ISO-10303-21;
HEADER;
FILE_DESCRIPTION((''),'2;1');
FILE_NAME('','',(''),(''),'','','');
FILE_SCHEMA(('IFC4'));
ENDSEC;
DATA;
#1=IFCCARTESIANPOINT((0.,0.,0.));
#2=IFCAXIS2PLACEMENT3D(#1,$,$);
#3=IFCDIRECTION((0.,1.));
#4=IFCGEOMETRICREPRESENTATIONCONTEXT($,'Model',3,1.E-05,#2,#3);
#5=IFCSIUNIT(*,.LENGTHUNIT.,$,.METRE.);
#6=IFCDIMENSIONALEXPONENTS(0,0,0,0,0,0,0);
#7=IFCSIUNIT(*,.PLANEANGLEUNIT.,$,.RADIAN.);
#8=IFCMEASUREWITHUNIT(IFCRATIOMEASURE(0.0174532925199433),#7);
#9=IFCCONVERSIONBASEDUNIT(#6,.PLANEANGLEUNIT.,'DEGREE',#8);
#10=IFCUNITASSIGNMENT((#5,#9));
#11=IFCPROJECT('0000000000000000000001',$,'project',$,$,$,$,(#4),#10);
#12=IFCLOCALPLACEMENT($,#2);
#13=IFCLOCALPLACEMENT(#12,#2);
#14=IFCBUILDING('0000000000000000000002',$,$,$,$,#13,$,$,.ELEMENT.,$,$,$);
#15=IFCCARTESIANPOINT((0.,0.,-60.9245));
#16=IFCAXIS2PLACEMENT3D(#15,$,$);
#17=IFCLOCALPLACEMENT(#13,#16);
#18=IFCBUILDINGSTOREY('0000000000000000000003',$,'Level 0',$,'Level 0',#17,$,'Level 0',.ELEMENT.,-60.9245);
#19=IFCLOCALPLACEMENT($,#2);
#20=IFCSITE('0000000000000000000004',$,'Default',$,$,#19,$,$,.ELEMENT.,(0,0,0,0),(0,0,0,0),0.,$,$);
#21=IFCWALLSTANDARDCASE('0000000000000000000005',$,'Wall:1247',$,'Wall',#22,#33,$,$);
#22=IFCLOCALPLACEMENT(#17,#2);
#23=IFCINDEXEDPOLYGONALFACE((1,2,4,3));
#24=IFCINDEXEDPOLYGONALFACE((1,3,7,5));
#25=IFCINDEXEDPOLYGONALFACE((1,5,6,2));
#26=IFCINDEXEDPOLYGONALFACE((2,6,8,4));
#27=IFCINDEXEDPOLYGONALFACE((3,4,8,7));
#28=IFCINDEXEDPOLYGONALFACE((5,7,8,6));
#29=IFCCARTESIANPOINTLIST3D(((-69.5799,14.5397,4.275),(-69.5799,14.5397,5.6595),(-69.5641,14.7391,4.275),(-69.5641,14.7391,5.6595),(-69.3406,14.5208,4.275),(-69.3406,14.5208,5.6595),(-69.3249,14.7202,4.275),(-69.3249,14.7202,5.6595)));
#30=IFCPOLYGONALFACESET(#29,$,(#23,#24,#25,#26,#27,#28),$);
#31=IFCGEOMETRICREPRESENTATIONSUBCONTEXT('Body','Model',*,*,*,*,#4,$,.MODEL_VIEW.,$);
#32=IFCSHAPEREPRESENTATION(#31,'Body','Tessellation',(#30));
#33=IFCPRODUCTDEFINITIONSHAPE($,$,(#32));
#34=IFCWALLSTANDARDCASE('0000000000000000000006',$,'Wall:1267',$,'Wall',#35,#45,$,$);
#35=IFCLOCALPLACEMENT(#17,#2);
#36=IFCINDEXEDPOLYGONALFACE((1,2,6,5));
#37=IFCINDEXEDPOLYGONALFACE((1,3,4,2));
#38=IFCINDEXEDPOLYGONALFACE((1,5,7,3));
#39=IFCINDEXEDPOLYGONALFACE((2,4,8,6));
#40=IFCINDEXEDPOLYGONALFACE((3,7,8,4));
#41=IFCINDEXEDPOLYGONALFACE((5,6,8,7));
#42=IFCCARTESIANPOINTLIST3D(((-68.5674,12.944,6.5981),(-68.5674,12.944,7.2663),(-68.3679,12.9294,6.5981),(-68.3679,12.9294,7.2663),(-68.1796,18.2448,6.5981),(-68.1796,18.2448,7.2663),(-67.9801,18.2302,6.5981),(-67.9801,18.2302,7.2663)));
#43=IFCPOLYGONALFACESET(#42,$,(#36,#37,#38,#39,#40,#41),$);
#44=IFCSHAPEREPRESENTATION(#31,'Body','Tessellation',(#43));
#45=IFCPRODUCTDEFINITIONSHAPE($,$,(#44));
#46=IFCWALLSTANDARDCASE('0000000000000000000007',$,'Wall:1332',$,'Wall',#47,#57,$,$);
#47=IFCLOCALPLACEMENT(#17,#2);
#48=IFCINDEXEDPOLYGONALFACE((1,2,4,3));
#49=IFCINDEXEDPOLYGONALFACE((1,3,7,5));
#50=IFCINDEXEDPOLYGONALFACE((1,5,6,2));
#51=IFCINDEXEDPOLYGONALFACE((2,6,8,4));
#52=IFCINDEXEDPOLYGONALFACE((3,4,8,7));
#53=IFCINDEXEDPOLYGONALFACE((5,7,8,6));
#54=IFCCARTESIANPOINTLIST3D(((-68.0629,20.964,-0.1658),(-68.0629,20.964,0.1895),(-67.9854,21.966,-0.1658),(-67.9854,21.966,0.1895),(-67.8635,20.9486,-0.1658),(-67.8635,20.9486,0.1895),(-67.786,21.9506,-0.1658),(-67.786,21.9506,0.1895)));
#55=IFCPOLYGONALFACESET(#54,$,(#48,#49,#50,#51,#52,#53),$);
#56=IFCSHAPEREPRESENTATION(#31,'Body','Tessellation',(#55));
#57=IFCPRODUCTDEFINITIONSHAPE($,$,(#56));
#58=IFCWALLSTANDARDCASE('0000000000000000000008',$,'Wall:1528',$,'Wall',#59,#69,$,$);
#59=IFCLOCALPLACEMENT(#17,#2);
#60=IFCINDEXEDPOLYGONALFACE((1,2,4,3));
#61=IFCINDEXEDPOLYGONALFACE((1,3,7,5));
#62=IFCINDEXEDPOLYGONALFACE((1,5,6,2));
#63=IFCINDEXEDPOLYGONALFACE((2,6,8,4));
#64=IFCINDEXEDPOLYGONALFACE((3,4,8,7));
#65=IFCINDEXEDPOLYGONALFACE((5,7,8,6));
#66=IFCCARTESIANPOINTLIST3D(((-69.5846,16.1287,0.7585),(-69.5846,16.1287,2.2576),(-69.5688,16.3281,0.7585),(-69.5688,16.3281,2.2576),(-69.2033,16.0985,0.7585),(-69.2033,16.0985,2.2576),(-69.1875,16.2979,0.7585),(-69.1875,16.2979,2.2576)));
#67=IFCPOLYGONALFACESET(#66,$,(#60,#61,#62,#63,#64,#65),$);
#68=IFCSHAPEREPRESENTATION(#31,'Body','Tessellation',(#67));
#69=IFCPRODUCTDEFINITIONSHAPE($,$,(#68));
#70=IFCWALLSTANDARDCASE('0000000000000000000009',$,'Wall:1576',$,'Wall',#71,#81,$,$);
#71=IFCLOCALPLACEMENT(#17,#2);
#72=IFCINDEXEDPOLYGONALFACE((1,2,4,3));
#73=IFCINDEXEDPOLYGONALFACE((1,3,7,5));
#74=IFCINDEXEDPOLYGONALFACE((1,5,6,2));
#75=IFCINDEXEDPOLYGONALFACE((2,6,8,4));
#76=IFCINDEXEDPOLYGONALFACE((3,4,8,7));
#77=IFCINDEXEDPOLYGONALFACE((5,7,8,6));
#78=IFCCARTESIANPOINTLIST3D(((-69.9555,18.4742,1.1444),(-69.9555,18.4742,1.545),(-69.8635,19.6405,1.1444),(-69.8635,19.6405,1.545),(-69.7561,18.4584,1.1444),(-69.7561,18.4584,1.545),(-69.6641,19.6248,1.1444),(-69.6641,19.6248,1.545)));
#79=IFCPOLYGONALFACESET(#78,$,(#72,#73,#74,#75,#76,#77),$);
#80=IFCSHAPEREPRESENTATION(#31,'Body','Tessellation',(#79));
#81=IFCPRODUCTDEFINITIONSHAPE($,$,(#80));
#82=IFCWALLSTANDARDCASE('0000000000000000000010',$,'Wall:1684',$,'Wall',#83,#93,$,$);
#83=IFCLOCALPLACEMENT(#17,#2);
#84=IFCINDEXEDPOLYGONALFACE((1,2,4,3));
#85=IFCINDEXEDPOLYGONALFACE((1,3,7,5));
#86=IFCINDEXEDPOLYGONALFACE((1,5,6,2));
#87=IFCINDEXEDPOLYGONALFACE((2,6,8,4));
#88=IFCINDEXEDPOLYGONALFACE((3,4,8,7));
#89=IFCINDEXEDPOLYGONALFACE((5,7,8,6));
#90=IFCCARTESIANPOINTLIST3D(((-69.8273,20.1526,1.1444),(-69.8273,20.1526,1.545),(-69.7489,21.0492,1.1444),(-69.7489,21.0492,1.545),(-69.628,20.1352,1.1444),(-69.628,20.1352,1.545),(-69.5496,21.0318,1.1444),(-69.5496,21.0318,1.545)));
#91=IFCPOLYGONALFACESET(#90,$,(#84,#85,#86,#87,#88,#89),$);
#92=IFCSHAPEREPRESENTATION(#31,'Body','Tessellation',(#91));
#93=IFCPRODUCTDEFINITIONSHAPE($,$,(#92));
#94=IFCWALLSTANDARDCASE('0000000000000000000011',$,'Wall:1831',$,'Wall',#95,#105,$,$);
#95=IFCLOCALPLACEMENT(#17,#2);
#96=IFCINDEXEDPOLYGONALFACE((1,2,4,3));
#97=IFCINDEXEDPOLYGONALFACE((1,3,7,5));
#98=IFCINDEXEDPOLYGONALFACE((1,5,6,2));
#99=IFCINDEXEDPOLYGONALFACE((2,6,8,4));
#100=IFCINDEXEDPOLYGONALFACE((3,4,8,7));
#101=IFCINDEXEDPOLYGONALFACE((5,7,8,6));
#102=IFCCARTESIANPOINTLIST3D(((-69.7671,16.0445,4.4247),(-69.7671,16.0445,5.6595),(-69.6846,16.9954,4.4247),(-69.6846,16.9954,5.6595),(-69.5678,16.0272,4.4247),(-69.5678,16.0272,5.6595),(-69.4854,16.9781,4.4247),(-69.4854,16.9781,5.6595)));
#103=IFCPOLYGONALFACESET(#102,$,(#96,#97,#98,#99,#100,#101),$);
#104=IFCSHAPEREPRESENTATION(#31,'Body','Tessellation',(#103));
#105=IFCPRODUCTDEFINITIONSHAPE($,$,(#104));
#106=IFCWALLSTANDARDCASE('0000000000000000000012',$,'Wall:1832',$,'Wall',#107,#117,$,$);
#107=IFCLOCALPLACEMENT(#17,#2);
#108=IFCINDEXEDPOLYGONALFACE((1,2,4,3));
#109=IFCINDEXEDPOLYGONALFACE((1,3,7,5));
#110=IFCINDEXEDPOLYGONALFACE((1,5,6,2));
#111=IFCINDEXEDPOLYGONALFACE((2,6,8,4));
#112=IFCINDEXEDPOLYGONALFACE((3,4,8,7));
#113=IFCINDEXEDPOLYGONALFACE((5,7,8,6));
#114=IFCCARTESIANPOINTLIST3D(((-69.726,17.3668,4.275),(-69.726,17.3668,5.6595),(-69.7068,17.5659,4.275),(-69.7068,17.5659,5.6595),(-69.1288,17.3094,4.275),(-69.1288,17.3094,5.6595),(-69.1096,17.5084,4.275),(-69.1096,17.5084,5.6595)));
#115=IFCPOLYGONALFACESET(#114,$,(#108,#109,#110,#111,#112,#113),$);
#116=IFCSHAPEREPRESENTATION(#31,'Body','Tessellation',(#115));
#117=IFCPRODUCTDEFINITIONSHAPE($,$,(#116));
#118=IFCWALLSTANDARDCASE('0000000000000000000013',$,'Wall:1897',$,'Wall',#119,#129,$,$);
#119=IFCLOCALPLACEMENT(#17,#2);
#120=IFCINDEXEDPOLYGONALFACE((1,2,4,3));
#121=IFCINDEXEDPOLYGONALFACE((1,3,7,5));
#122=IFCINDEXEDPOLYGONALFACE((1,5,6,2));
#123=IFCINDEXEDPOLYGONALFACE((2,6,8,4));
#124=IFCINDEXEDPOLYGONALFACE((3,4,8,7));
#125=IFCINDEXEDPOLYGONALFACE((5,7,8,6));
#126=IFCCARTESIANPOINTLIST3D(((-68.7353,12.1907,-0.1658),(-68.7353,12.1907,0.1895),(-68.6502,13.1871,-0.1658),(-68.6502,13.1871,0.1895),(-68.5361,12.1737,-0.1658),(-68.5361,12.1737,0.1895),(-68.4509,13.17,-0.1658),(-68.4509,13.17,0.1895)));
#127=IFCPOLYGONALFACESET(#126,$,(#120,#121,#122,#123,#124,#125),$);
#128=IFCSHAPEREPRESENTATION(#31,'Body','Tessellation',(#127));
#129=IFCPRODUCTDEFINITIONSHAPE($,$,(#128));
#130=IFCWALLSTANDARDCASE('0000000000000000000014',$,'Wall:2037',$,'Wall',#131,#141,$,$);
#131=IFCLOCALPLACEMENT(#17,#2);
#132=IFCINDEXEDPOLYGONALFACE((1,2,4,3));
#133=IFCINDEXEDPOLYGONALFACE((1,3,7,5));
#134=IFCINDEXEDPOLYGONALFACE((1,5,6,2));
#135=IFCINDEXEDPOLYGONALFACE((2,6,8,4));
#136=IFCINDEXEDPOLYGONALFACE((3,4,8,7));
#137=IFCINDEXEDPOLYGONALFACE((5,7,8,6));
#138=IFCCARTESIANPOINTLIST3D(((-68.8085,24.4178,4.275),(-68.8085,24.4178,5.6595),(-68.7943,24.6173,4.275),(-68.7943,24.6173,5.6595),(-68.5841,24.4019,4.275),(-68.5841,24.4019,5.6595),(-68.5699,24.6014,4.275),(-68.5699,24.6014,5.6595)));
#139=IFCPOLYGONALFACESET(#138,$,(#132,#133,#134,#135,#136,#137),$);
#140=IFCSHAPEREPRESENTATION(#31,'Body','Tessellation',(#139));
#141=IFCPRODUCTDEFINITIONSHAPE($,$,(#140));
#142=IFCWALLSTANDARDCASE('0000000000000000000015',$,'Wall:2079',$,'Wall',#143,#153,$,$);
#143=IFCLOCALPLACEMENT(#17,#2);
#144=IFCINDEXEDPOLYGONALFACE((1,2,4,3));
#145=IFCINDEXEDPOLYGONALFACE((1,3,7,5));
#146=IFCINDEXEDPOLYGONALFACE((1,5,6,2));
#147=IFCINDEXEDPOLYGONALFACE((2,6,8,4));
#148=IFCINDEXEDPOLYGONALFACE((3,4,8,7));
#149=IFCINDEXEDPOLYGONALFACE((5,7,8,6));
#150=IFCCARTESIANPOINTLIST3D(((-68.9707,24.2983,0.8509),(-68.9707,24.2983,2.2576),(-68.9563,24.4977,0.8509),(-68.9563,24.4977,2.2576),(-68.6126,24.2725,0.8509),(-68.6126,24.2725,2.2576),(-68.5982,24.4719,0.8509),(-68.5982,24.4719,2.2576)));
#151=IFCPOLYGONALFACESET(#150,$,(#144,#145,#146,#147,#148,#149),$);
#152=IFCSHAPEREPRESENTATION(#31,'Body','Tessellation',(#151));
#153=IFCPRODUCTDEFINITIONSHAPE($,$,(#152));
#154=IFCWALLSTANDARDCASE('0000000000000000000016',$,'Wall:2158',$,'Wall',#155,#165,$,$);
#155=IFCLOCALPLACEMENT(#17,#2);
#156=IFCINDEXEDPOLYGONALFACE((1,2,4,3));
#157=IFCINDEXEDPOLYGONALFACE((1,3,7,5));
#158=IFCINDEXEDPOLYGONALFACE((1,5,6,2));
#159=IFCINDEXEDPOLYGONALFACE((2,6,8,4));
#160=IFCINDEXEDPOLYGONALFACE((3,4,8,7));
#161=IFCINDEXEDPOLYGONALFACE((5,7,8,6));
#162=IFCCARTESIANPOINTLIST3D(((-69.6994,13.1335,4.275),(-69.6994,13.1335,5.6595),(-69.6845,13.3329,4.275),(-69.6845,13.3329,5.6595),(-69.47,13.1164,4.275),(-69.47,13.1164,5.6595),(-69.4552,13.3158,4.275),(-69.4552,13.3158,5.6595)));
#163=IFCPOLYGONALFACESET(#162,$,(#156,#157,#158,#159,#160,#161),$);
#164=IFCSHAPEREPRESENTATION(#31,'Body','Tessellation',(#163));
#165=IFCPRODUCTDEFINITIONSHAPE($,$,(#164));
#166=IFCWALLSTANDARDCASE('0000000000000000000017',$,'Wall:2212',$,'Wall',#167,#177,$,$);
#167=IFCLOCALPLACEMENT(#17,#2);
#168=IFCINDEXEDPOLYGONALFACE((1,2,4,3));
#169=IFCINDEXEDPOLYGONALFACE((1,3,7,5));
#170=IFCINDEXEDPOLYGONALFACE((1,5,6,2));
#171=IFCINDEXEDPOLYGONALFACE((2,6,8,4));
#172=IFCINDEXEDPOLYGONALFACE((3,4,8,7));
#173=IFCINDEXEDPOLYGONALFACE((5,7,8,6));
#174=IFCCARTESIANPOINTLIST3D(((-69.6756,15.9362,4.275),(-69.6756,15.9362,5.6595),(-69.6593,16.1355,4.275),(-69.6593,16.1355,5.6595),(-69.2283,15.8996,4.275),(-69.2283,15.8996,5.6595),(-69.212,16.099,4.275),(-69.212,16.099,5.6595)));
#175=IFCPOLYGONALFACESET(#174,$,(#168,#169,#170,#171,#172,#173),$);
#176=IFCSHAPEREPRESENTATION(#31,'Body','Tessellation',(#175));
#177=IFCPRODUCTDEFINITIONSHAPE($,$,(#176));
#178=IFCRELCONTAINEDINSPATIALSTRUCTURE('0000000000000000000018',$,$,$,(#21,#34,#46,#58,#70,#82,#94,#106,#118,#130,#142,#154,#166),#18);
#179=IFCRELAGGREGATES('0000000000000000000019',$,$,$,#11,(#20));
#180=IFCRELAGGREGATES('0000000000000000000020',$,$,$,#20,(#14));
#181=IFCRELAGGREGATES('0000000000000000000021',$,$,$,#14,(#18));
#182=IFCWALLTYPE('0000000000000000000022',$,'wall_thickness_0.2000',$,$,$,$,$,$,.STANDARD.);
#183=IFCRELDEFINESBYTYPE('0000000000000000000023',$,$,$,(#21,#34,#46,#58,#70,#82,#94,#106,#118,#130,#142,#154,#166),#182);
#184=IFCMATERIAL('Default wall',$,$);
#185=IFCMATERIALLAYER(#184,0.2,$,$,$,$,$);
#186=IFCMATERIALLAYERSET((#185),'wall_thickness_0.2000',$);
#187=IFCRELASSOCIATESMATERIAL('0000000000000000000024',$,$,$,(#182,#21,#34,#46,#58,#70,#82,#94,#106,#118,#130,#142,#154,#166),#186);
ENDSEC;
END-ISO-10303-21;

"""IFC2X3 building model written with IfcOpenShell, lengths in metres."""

from ifc_helpers import new_model, entity, si_unit, converted_unit, direction, frame, origin, place, context, subcontext, project, spatial, polyline, outline, extrude, material, layer, layer_set, layer_usage, type_object, element, save


model = new_model("IFC2X3")

# Units and contexts
model_context = context("Model", 3, precision=1e-05, world=origin(), true_north=direction((0.0, 1.0)))
body_context = subcontext(model_context, "Body", "Model", "MODEL_VIEW")
ifc_project = project(units=[si_unit("LENGTHUNIT", "METRE"), converted_unit("PLANEANGLEUNIT", "DEGREE", entity("IfcRatioMeasure", 0.0174532925199433), si_unit("PLANEANGLEUNIT", "RADIAN"), dimensions=[0, 0, 0, 0, 0, 0, 0])], contexts=[model_context])

# Site, building, storey
site_placement = place(None, origin())
site = spatial("IfcSite", under=ifc_project, at=site_placement, Name="Default", CompositionType="ELEMENT", RefLatitude=(0, 0, 0, 0), RefLongitude=(0, 0, 0, 0), RefElevation=0.0)
placement_1 = place(None, origin())
building_placement = place(placement_1, origin())
building = spatial("IfcBuilding", under=site, at=building_placement, CompositionType="ELEMENT")
storey_placement = place(building_placement, frame((0.0, 0.0, -60.9245)))
storey = spatial("IfcBuildingStorey", under=building, at=storey_placement, Name="Level 0", ObjectType="Level 0", LongName="Level 0", CompositionType="ELEMENT", Elevation=-60.9245)

# Walls
ifc_material = material(Name="Default wall")
ifc_layer = layer(ifc_material, 0.2)
ifc_layer_set = layer_set([ifc_layer], Name="wall_thickness_0.2000")
ifc_layer_usage = layer_usage(ifc_layer_set, "AXIS2", "POSITIVE", -0.1)
wall_type = type_object("IfcWallType", Name="wall_thickness_0.2000", PredefinedType="STANDARD", material=ifc_layer_set)
placement_2 = place(building_placement, frame((0.0, 0.0, -56.6495)))
wall_1_placement = place(placement_2, frame((-69.3328, 14.6205, 0.0), z_axis=(0.0, 0.0, 1.0), x_axis=(-0.996902, 0.078658, 0.0)))
element("IfcWallStandardCase", 1, at=wall_1_placement, inside=storey, type_object=wall_type, material=ifc_layer_usage, Name="Wall:1247", ObjectType="Wall", context=body_context, shape_type="SweptSolid", body=[
    extrude(outline(polyline([(0.24, -0.1), (0.24, 0.1), (0.0, 0.1), (0.0, -0.1), (0.24, -0.1)])), origin(), (0.0, 0.0, 1.0), 1.3845),
])
placement_3 = place(building_placement, frame((0.0, 0.0, -54.3264)))
wall_2_placement = place(placement_3, frame((-68.4676, 12.9367, 0.0), z_axis=(0.0, 0.0, 1.0), x_axis=(0.072961, 0.997335, 0.0)))
element("IfcWallStandardCase", 2, at=wall_2_placement, inside=storey, type_object=wall_type, material=ifc_layer_usage, Name="Wall:1267", ObjectType="Wall", context=body_context, shape_type="SweptSolid", body=[
    extrude(outline(polyline([(5.315, -0.1), (5.315, 0.1), (0.0, 0.1), (0.0, -0.1), (5.315, -0.1)])), origin(), (0.0, 0.0, 1.0), 0.6682),
])
placement_4 = place(building_placement, frame((0.0, 0.0, -61.0903)))
wall_3_placement = place(placement_4, frame((-67.9632, 20.9563, 0.0), z_axis=(0.0, 0.0, 1.0), x_axis=(0.077076, 0.997025, 0.0)))
element("IfcWallStandardCase", 3, at=wall_3_placement, inside=storey, type_object=wall_type, material=ifc_layer_usage, Name="Wall:1332", ObjectType="Wall", context=body_context, shape_type="SweptSolid", body=[
    extrude(outline(polyline([(1.005, -0.1), (1.005, 0.1), (0.0, 0.1), (0.0, -0.1), (1.005, -0.1)])), origin(), (0.0, 0.0, 1.0), 0.3553),
])
placement_5 = place(building_placement, frame((0.0, 0.0, -60.166)))
wall_4_placement = place(placement_5, frame((-69.1954, 16.1982, 0.0), z_axis=(0.0, 0.0, 1.0), x_axis=(-0.996881, 0.078913, 0.0)))
element("IfcWallStandardCase", 4, at=wall_4_placement, inside=storey, type_object=wall_type, material=ifc_layer_usage, Name="Wall:1528", ObjectType="Wall", context=body_context, shape_type="SweptSolid", body=[
    extrude(outline(polyline([(0.3825, -0.1), (0.3825, 0.1), (0.0, 0.1), (0.0, -0.1), (0.3825, -0.1)])), origin(), (0.0, 0.0, 1.0), 1.4991),
])
placement_6 = place(building_placement, frame((0.0, 0.0, -59.7801)))
wall_5_placement = place(placement_6, frame((-69.8558, 18.4663, 0.0), z_axis=(0.0, 0.0, 1.0), x_axis=(0.078641, 0.996903, 0.0)))
element("IfcWallStandardCase", 5, at=wall_5_placement, inside=storey, type_object=wall_type, material=ifc_layer_usage, Name="Wall:1576", ObjectType="Wall", context=body_context, shape_type="SweptSolid", body=[
    extrude(outline(polyline([(1.17, -0.1), (1.17, 0.1), (0.0, 0.1), (0.0, -0.1), (1.17, -0.1)])), origin(), (0.0, 0.0, 1.0), 0.4006),
])
placement_7 = place(building_placement, frame((0.0, 0.0, -59.7801)))
wall_6_placement = place(placement_7, frame((-69.7277, 20.1439, 0.0), z_axis=(0.0, 0.0, 1.0), x_axis=(0.087136, 0.996196, 0.0)))
element("IfcWallStandardCase", 6, at=wall_6_placement, inside=storey, type_object=wall_type, material=ifc_layer_usage, Name="Wall:1684", ObjectType="Wall", context=body_context, shape_type="SweptSolid", body=[
    extrude(outline(polyline([(0.9, -0.1), (0.9, 0.1), (0.0, 0.1), (0.0, -0.1), (0.9, -0.1)])), origin(), (0.0, 0.0, 1.0), 0.4006),
])
placement_8 = place(building_placement, frame((0.0, 0.0, -56.4998)))
wall_7_placement = place(placement_8, frame((-69.585, 16.9868, 0.0), z_axis=(0.0, 0.0, 1.0), x_axis=(-0.086399, -0.996261, 0.0)))
element("IfcWallStandardCase", 7, at=wall_7_placement, inside=storey, type_object=wall_type, material=ifc_layer_usage, Name="Wall:1831", ObjectType="Wall", context=body_context, shape_type="SweptSolid", body=[
    extrude(outline(polyline([(0.9545, -0.1), (0.9545, 0.1), (0.0, 0.1), (0.0, -0.1), (0.9545, -0.1)])), origin(), (0.0, 0.0, 1.0), 1.2348),
])
placement_9 = place(building_placement, frame((0.0, 0.0, -56.6495)))
wall_8_placement = place(placement_9, frame((-69.1192, 17.4089, 0.0), z_axis=(0.0, 0.0, 1.0), x_axis=(-0.995401, 0.095793, 0.0)))
element("IfcWallStandardCase", 8, at=wall_8_placement, inside=storey, type_object=wall_type, material=ifc_layer_usage, Name="Wall:1832", ObjectType="Wall", context=body_context, shape_type="SweptSolid", body=[
    extrude(outline(polyline([(0.6, -0.1), (0.6, 0.1), (0.0, 0.1), (0.0, -0.1), (0.6, -0.1)])), origin(), (0.0, 0.0, 1.0), 1.3845),
])
placement_10 = place(building_placement, frame((0.0, 0.0, -61.0903)))
wall_9_placement = place(placement_10, frame((-68.6357, 12.1822, 0.0), z_axis=(0.0, 0.0, 1.0), x_axis=(0.085167, 0.996367, 0.0)))
element("IfcWallStandardCase", 9, at=wall_9_placement, inside=storey, type_object=wall_type, material=ifc_layer_usage, Name="Wall:1897", ObjectType="Wall", context=body_context, shape_type="SweptSolid", body=[
    extrude(outline(polyline([(1.0, -0.1), (1.0, 0.1), (0.0, 0.1), (0.0, -0.1), (1.0, -0.1)])), origin(), (0.0, 0.0, 1.0), 0.3553),
])
placement_11 = place(building_placement, frame((0.0, 0.0, -56.6495)))
wall_10_placement = place(placement_11, frame((-68.577, 24.5016, 0.0), z_axis=(0.0, 0.0, 1.0), x_axis=(-0.99749, 0.07081, 0.0)))
element("IfcWallStandardCase", 10, at=wall_10_placement, inside=storey, type_object=wall_type, material=ifc_layer_usage, Name="Wall:2037", ObjectType="Wall", context=body_context, shape_type="SweptSolid", body=[
    extrude(outline(polyline([(0.225, -0.1), (0.225, 0.1), (0.0, 0.1), (0.0, -0.1), (0.225, -0.1)])), origin(), (0.0, 0.0, 1.0), 1.3845),
])
placement_12 = place(building_placement, frame((0.0, 0.0, -60.0736)))
wall_11_placement = place(placement_12, frame((-68.6054, 24.3722, 0.0), z_axis=(0.0, 0.0, 1.0), x_axis=(-0.997413, 0.071887, 0.0)))
element("IfcWallStandardCase", 11, at=wall_11_placement, inside=storey, type_object=wall_type, material=ifc_layer_usage, Name="Wall:2079", ObjectType="Wall", context=body_context, shape_type="SweptSolid", body=[
    extrude(outline(polyline([(0.359, -0.1), (0.359, 0.1), (0.0, 0.1), (0.0, -0.1), (0.359, -0.1)])), origin(), (0.0, 0.0, 1.0), 1.4068),
])
placement_13 = place(building_placement, frame((0.0, 0.0, -56.6495)))
wall_12_placement = place(placement_13, frame((-69.4626, 13.2161, 0.0), z_axis=(0.0, 0.0, 1.0), x_axis=(-0.997233, 0.074341, 0.0)))
element("IfcWallStandardCase", 12, at=wall_12_placement, inside=storey, type_object=wall_type, material=ifc_layer_usage, Name="Wall:2158", ObjectType="Wall", context=body_context, shape_type="SweptSolid", body=[
    extrude(outline(polyline([(0.23, -0.1), (0.23, 0.1), (0.0, 0.1), (0.0, -0.1), (0.23, -0.1)])), origin(), (0.0, 0.0, 1.0), 1.3845),
])
placement_14 = place(building_placement, frame((0.0, 0.0, -56.6495)))
wall_13_placement = place(placement_14, frame((-69.2202, 15.9993, 0.0), z_axis=(0.0, 0.0, 1.0), x_axis=(-0.996681, 0.081409, 0.0)))
element("IfcWallStandardCase", 13, at=wall_13_placement, inside=storey, type_object=wall_type, material=ifc_layer_usage, Name="Wall:2212", ObjectType="Wall", context=body_context, shape_type="SweptSolid", body=[
    extrude(outline(polyline([(0.4488, -0.1), (0.4488, 0.1), (0.0, 0.1), (0.0, -0.1), (0.4488, -0.1)])), origin(), (0.0, 0.0, 1.0), 1.3845),
])

save(model, "model.ifc")
